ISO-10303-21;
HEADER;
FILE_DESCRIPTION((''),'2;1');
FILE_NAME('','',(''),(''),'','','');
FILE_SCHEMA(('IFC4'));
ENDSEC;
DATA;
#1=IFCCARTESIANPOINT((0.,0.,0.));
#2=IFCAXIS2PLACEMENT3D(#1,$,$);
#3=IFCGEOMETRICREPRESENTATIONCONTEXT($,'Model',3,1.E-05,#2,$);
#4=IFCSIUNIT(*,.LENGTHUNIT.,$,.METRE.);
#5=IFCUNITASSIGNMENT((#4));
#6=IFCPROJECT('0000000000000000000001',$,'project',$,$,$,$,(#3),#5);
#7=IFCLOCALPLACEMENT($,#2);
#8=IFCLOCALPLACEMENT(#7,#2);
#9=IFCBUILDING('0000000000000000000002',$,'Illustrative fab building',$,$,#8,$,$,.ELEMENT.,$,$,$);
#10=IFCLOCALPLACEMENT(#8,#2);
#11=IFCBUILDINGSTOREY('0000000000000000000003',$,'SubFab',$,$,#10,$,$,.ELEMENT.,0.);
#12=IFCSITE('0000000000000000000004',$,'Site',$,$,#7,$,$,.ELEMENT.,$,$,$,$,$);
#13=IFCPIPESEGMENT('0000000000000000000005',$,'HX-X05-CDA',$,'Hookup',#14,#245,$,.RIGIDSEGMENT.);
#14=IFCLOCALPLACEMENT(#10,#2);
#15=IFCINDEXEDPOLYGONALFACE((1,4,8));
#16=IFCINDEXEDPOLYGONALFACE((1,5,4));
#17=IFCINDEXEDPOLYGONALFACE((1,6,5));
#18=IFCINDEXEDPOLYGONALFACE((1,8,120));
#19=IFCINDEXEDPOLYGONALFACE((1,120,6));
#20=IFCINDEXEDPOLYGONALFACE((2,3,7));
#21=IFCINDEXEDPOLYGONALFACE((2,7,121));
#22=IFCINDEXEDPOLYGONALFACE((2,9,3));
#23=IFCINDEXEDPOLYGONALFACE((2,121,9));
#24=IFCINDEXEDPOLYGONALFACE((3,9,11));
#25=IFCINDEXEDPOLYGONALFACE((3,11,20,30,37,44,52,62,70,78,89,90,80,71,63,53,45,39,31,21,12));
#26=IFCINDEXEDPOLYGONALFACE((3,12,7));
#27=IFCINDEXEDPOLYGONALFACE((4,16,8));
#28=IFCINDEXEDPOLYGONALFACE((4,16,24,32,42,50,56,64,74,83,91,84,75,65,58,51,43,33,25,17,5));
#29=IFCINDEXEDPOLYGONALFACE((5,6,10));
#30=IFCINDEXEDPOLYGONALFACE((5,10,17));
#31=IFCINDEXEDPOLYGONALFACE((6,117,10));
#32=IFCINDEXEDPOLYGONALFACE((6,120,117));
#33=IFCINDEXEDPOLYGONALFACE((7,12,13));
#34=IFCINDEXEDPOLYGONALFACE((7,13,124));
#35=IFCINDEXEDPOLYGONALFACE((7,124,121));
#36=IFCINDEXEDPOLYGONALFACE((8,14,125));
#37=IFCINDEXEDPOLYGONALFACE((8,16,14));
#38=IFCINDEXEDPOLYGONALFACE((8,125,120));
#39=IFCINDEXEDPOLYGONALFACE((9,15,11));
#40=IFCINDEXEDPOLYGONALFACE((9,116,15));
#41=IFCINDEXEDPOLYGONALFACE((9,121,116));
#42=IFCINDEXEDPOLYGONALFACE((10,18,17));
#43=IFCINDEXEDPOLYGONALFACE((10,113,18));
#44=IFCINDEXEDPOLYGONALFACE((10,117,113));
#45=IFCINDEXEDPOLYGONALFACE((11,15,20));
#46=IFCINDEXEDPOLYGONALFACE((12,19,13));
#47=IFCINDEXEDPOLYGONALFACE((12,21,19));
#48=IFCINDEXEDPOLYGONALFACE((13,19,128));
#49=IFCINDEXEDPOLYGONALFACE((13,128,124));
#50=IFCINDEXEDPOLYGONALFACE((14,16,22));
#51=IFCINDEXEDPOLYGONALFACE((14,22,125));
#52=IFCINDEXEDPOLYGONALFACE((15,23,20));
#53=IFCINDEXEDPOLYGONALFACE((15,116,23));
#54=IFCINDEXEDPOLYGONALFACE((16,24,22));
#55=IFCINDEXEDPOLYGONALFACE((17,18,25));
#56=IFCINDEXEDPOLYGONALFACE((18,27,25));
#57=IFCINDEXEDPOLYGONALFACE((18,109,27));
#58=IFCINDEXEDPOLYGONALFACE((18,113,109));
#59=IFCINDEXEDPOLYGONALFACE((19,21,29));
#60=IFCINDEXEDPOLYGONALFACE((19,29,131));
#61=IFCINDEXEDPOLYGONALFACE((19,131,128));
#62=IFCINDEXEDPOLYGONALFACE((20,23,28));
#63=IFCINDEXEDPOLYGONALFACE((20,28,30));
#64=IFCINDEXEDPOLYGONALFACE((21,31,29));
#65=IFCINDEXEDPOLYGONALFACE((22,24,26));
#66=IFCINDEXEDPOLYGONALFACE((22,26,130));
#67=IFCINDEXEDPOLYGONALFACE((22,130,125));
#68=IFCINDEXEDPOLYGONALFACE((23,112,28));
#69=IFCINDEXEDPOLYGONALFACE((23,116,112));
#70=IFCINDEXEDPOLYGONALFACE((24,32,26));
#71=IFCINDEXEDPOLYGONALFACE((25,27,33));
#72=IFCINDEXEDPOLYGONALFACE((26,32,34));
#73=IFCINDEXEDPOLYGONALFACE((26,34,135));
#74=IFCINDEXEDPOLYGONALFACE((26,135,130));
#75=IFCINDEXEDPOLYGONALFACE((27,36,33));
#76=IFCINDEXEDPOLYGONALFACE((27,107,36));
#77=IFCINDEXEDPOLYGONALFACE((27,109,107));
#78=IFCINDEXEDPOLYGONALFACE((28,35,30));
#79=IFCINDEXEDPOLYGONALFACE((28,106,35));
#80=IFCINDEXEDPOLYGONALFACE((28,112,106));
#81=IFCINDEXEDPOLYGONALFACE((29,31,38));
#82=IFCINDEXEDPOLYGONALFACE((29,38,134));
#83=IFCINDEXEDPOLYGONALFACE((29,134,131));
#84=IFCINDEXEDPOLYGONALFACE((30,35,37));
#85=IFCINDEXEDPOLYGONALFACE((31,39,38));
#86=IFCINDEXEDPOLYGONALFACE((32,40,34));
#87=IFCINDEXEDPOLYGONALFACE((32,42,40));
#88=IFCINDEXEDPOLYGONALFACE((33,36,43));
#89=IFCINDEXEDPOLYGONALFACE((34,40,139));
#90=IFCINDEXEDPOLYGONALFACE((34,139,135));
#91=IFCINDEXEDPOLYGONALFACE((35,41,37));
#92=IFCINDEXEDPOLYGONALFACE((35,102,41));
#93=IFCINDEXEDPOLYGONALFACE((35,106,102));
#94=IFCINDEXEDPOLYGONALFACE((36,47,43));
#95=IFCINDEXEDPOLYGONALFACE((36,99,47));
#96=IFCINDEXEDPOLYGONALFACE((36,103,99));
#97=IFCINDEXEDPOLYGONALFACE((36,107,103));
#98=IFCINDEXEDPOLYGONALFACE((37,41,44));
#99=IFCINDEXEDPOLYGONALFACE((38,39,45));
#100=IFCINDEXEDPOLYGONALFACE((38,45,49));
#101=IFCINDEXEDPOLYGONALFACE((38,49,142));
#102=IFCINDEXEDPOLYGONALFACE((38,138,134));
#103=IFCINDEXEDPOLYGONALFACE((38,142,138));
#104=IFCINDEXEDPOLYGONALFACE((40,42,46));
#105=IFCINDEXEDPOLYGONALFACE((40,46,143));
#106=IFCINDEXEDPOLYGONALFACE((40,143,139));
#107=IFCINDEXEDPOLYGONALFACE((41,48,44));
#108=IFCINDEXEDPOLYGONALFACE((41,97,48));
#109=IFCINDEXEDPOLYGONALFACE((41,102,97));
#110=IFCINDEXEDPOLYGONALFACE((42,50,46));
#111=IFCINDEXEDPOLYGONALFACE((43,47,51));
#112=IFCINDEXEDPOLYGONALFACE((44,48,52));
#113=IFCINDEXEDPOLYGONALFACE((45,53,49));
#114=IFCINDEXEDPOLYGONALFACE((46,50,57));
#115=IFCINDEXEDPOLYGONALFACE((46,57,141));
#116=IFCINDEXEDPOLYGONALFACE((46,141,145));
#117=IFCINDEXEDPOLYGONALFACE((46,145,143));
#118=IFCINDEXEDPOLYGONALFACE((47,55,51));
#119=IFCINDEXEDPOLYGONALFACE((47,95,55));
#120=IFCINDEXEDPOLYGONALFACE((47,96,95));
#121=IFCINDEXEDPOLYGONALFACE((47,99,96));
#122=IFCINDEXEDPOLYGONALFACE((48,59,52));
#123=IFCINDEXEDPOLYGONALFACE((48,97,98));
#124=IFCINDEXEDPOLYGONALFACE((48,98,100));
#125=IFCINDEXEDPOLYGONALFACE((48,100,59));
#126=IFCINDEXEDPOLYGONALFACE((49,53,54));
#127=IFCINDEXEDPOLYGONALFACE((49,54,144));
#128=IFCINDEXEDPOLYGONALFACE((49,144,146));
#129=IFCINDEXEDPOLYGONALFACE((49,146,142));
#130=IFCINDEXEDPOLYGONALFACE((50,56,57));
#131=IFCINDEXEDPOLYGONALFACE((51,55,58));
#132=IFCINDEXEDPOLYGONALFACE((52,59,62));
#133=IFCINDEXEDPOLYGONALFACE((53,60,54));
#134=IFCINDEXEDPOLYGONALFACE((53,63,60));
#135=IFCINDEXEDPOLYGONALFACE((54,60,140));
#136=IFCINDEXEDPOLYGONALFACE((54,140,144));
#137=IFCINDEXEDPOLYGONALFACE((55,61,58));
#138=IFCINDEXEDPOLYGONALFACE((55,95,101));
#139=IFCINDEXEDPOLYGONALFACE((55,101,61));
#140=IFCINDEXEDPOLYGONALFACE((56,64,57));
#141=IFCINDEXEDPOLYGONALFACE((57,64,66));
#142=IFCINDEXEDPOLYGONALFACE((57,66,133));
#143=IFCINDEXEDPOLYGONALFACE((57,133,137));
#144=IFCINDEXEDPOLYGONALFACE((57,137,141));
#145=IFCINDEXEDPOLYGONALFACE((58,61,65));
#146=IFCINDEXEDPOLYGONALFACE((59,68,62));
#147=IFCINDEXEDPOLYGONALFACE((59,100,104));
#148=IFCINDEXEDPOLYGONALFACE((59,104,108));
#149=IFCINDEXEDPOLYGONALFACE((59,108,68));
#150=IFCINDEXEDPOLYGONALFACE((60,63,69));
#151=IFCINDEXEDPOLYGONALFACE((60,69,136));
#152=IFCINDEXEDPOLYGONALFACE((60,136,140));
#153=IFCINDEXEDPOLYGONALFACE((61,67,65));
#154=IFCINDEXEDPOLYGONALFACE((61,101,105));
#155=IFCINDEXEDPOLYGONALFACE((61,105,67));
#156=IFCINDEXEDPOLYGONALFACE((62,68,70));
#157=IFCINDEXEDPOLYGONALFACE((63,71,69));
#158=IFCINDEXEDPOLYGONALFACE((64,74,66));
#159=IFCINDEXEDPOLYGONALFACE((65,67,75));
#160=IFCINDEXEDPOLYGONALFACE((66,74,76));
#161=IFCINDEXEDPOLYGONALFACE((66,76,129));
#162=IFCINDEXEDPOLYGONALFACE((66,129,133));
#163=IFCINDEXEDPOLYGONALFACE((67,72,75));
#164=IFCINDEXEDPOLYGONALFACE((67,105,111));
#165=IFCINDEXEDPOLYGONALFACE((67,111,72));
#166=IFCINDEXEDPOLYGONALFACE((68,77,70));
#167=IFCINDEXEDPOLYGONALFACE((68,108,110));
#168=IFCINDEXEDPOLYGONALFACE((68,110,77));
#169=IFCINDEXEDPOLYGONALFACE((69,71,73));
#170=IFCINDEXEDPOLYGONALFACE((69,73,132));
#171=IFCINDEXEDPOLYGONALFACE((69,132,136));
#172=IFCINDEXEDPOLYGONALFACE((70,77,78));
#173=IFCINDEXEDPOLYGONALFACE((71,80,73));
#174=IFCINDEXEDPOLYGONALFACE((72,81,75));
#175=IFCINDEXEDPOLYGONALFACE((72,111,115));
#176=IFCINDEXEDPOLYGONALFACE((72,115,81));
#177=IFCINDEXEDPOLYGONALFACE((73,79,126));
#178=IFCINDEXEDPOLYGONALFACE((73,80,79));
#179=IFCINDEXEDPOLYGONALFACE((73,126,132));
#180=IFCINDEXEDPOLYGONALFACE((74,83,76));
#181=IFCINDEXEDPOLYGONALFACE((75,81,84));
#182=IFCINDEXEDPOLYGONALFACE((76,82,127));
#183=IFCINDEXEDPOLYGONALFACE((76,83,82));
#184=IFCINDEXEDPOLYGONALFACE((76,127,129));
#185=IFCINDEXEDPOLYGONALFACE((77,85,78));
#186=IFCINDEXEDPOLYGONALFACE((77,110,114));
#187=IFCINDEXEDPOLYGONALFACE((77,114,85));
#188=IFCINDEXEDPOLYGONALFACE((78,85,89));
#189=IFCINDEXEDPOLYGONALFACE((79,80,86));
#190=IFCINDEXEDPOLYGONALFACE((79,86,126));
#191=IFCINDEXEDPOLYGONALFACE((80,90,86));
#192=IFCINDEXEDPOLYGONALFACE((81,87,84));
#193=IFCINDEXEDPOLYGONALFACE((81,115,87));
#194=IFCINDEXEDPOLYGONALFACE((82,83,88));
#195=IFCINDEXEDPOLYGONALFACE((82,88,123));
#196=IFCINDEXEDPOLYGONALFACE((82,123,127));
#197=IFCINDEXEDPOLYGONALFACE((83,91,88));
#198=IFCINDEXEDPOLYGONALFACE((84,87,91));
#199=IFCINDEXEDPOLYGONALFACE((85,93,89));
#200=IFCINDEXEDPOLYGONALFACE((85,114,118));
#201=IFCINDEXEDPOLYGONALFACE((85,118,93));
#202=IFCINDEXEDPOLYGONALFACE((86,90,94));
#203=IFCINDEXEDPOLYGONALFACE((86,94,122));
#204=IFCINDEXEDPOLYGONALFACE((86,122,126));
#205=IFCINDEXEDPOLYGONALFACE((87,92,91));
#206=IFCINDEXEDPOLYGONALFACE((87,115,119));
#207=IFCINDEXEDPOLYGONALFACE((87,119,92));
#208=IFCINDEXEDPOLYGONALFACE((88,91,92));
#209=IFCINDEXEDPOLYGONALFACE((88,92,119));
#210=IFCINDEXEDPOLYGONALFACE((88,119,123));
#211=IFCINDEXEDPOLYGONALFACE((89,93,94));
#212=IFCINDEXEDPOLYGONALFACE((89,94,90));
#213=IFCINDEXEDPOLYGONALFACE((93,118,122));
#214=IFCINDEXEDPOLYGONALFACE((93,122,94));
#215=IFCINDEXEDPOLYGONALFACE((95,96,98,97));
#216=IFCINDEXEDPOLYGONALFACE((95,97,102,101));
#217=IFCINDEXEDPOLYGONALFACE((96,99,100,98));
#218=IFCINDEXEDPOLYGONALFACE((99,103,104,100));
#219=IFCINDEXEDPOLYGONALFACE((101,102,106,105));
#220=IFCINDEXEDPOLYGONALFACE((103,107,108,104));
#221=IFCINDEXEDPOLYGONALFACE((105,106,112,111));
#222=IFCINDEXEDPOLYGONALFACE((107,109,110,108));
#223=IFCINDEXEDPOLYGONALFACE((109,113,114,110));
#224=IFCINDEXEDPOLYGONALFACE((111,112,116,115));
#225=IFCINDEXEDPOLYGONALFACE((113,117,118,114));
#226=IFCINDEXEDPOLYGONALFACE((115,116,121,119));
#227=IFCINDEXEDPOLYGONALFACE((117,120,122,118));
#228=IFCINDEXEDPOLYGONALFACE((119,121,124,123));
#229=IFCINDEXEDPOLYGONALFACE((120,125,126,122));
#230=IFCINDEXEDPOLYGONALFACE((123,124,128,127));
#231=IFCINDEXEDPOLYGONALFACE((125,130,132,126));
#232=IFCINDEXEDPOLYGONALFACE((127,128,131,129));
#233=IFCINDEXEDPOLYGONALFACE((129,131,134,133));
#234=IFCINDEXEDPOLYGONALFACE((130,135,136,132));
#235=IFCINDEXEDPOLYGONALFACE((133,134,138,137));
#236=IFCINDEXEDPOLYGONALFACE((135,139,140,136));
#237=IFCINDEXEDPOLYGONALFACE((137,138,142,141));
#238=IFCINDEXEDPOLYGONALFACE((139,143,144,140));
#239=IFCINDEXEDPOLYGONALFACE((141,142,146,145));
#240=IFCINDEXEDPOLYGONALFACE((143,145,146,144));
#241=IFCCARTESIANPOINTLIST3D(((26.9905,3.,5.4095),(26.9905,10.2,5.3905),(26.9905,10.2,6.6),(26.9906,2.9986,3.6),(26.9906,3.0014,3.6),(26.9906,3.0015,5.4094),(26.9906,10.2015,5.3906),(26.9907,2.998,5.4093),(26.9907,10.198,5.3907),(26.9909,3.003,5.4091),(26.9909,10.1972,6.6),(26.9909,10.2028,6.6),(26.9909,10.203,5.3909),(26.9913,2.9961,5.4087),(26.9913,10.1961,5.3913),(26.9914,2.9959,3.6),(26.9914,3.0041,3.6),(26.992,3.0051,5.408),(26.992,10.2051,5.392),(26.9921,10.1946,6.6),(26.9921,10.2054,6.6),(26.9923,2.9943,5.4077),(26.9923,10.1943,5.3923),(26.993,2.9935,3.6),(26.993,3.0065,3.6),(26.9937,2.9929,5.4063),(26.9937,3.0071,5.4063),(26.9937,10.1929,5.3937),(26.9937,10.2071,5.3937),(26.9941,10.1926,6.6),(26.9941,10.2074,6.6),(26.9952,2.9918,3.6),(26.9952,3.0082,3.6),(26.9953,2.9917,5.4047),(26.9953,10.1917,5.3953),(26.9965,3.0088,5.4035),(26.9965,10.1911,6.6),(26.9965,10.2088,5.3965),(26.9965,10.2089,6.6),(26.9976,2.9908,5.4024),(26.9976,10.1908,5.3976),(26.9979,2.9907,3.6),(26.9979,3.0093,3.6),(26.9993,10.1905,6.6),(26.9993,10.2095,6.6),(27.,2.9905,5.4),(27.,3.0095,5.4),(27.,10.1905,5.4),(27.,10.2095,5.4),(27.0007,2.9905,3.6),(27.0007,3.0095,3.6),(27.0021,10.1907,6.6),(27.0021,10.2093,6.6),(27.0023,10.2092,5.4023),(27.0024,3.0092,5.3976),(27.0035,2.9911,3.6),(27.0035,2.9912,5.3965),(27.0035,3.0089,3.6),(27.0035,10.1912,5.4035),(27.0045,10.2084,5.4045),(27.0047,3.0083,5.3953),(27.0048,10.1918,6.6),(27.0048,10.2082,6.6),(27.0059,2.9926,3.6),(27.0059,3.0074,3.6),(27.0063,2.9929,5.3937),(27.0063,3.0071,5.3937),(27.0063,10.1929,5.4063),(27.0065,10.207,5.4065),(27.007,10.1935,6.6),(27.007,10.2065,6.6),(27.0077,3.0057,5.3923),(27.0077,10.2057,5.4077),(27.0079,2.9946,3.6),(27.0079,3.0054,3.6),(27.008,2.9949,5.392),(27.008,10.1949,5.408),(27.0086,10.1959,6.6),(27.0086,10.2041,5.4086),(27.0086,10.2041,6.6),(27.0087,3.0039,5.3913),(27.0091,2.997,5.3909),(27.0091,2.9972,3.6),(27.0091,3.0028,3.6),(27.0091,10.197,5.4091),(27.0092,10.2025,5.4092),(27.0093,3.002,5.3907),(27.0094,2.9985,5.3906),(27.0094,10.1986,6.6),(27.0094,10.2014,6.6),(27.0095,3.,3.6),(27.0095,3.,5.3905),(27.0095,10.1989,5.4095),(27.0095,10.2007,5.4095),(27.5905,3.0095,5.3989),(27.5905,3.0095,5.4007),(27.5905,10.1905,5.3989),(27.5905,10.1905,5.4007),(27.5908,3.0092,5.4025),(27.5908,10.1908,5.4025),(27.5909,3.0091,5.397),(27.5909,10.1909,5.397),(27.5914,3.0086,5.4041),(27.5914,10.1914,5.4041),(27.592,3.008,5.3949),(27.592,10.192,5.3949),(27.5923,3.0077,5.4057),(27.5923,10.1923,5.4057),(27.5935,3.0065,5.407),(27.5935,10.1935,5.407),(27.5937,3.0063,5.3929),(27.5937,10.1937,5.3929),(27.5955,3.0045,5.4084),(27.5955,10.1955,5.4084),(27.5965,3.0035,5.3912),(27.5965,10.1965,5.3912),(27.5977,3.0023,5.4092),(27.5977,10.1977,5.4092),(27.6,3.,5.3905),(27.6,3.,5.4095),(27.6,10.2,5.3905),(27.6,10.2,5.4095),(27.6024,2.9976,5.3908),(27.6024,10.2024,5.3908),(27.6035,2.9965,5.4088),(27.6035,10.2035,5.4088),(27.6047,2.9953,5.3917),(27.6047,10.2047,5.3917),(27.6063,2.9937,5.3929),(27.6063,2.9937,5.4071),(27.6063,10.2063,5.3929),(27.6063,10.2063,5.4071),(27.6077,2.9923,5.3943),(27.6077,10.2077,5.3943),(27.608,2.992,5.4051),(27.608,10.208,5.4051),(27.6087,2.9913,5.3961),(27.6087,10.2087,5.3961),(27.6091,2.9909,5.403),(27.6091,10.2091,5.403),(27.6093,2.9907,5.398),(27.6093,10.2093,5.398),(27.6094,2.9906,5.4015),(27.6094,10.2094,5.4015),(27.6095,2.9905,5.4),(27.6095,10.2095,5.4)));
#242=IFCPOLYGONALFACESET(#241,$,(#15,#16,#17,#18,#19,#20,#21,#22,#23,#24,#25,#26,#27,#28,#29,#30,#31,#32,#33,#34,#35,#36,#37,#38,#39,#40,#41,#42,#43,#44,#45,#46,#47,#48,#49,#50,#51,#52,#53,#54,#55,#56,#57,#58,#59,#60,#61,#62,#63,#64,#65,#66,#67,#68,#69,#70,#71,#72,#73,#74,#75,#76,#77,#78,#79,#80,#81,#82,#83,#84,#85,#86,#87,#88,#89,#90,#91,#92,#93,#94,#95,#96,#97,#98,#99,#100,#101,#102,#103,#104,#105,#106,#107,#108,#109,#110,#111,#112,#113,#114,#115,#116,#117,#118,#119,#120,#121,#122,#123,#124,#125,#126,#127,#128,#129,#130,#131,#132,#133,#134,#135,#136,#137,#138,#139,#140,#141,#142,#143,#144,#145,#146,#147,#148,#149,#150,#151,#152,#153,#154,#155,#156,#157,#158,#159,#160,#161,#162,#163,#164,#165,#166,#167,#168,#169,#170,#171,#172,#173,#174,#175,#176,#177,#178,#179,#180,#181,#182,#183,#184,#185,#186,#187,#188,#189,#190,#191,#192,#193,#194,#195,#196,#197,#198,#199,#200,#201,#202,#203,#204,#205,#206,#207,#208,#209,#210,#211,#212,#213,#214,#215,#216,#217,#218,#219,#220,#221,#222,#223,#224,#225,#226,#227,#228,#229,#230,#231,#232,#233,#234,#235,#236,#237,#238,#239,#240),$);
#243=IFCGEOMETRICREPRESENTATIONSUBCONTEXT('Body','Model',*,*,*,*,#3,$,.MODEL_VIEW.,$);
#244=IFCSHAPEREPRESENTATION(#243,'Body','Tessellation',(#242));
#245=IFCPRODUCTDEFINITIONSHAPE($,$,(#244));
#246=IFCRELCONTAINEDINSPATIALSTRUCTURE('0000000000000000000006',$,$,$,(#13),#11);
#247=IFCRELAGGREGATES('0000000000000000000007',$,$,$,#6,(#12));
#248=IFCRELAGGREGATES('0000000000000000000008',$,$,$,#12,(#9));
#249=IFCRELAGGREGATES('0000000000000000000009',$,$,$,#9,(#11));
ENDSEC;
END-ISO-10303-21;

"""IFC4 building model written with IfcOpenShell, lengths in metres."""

from ifc_helpers import new_model, entity, si_unit, origin, place, context, subcontext, project, spatial, element, save


model = new_model("IFC4")

# Units and contexts
model_context = context("Model", 3, precision=1e-05, world=origin())
body_context = subcontext(model_context, "Body", "Model", "MODEL_VIEW")
ifc_project = project(units=[si_unit("LENGTHUNIT", "METRE")], contexts=[model_context])

# Site, building, storey
site_placement = place(None, origin())
site = spatial("IfcSite", under=ifc_project, at=site_placement, Name="Site", CompositionType="ELEMENT")
building_placement = place(site_placement, origin())
building = spatial("IfcBuilding", under=site, at=building_placement, Name="Illustrative fab building", CompositionType="ELEMENT")
storey_placement = place(building_placement, origin())
storey = spatial("IfcBuildingStorey", under=building, at=storey_placement, Name="SubFab", CompositionType="ELEMENT", Elevation=0.0)

# Pipe segment
pipe_segment_1_placement = place(storey_placement, origin())
element("IfcPipeSegment", 1, at=pipe_segment_1_placement, inside=storey, Name="HX-X05-CDA", ObjectType="Hookup", PredefinedType="RIGIDSEGMENT", context=body_context, shape_type="AdvancedSweptSolid", body=[
    entity("IfcSweptDiskSolid", entity("IfcPolyline", [entity("IfcCartesianPoint", [27.0, 3.0, 3.6]), entity("IfcCartesianPoint", [27.0, 3.0, 5.4]), entity("IfcCartesianPoint", [27.6, 3.0, 5.4]), entity("IfcCartesianPoint", [27.6, 10.2, 5.4]), entity("IfcCartesianPoint", [27.0, 10.2, 5.4]), entity("IfcCartesianPoint", [27.0, 10.2, 6.6])]), 0.0095),
])

save(model, "model.ifc")
